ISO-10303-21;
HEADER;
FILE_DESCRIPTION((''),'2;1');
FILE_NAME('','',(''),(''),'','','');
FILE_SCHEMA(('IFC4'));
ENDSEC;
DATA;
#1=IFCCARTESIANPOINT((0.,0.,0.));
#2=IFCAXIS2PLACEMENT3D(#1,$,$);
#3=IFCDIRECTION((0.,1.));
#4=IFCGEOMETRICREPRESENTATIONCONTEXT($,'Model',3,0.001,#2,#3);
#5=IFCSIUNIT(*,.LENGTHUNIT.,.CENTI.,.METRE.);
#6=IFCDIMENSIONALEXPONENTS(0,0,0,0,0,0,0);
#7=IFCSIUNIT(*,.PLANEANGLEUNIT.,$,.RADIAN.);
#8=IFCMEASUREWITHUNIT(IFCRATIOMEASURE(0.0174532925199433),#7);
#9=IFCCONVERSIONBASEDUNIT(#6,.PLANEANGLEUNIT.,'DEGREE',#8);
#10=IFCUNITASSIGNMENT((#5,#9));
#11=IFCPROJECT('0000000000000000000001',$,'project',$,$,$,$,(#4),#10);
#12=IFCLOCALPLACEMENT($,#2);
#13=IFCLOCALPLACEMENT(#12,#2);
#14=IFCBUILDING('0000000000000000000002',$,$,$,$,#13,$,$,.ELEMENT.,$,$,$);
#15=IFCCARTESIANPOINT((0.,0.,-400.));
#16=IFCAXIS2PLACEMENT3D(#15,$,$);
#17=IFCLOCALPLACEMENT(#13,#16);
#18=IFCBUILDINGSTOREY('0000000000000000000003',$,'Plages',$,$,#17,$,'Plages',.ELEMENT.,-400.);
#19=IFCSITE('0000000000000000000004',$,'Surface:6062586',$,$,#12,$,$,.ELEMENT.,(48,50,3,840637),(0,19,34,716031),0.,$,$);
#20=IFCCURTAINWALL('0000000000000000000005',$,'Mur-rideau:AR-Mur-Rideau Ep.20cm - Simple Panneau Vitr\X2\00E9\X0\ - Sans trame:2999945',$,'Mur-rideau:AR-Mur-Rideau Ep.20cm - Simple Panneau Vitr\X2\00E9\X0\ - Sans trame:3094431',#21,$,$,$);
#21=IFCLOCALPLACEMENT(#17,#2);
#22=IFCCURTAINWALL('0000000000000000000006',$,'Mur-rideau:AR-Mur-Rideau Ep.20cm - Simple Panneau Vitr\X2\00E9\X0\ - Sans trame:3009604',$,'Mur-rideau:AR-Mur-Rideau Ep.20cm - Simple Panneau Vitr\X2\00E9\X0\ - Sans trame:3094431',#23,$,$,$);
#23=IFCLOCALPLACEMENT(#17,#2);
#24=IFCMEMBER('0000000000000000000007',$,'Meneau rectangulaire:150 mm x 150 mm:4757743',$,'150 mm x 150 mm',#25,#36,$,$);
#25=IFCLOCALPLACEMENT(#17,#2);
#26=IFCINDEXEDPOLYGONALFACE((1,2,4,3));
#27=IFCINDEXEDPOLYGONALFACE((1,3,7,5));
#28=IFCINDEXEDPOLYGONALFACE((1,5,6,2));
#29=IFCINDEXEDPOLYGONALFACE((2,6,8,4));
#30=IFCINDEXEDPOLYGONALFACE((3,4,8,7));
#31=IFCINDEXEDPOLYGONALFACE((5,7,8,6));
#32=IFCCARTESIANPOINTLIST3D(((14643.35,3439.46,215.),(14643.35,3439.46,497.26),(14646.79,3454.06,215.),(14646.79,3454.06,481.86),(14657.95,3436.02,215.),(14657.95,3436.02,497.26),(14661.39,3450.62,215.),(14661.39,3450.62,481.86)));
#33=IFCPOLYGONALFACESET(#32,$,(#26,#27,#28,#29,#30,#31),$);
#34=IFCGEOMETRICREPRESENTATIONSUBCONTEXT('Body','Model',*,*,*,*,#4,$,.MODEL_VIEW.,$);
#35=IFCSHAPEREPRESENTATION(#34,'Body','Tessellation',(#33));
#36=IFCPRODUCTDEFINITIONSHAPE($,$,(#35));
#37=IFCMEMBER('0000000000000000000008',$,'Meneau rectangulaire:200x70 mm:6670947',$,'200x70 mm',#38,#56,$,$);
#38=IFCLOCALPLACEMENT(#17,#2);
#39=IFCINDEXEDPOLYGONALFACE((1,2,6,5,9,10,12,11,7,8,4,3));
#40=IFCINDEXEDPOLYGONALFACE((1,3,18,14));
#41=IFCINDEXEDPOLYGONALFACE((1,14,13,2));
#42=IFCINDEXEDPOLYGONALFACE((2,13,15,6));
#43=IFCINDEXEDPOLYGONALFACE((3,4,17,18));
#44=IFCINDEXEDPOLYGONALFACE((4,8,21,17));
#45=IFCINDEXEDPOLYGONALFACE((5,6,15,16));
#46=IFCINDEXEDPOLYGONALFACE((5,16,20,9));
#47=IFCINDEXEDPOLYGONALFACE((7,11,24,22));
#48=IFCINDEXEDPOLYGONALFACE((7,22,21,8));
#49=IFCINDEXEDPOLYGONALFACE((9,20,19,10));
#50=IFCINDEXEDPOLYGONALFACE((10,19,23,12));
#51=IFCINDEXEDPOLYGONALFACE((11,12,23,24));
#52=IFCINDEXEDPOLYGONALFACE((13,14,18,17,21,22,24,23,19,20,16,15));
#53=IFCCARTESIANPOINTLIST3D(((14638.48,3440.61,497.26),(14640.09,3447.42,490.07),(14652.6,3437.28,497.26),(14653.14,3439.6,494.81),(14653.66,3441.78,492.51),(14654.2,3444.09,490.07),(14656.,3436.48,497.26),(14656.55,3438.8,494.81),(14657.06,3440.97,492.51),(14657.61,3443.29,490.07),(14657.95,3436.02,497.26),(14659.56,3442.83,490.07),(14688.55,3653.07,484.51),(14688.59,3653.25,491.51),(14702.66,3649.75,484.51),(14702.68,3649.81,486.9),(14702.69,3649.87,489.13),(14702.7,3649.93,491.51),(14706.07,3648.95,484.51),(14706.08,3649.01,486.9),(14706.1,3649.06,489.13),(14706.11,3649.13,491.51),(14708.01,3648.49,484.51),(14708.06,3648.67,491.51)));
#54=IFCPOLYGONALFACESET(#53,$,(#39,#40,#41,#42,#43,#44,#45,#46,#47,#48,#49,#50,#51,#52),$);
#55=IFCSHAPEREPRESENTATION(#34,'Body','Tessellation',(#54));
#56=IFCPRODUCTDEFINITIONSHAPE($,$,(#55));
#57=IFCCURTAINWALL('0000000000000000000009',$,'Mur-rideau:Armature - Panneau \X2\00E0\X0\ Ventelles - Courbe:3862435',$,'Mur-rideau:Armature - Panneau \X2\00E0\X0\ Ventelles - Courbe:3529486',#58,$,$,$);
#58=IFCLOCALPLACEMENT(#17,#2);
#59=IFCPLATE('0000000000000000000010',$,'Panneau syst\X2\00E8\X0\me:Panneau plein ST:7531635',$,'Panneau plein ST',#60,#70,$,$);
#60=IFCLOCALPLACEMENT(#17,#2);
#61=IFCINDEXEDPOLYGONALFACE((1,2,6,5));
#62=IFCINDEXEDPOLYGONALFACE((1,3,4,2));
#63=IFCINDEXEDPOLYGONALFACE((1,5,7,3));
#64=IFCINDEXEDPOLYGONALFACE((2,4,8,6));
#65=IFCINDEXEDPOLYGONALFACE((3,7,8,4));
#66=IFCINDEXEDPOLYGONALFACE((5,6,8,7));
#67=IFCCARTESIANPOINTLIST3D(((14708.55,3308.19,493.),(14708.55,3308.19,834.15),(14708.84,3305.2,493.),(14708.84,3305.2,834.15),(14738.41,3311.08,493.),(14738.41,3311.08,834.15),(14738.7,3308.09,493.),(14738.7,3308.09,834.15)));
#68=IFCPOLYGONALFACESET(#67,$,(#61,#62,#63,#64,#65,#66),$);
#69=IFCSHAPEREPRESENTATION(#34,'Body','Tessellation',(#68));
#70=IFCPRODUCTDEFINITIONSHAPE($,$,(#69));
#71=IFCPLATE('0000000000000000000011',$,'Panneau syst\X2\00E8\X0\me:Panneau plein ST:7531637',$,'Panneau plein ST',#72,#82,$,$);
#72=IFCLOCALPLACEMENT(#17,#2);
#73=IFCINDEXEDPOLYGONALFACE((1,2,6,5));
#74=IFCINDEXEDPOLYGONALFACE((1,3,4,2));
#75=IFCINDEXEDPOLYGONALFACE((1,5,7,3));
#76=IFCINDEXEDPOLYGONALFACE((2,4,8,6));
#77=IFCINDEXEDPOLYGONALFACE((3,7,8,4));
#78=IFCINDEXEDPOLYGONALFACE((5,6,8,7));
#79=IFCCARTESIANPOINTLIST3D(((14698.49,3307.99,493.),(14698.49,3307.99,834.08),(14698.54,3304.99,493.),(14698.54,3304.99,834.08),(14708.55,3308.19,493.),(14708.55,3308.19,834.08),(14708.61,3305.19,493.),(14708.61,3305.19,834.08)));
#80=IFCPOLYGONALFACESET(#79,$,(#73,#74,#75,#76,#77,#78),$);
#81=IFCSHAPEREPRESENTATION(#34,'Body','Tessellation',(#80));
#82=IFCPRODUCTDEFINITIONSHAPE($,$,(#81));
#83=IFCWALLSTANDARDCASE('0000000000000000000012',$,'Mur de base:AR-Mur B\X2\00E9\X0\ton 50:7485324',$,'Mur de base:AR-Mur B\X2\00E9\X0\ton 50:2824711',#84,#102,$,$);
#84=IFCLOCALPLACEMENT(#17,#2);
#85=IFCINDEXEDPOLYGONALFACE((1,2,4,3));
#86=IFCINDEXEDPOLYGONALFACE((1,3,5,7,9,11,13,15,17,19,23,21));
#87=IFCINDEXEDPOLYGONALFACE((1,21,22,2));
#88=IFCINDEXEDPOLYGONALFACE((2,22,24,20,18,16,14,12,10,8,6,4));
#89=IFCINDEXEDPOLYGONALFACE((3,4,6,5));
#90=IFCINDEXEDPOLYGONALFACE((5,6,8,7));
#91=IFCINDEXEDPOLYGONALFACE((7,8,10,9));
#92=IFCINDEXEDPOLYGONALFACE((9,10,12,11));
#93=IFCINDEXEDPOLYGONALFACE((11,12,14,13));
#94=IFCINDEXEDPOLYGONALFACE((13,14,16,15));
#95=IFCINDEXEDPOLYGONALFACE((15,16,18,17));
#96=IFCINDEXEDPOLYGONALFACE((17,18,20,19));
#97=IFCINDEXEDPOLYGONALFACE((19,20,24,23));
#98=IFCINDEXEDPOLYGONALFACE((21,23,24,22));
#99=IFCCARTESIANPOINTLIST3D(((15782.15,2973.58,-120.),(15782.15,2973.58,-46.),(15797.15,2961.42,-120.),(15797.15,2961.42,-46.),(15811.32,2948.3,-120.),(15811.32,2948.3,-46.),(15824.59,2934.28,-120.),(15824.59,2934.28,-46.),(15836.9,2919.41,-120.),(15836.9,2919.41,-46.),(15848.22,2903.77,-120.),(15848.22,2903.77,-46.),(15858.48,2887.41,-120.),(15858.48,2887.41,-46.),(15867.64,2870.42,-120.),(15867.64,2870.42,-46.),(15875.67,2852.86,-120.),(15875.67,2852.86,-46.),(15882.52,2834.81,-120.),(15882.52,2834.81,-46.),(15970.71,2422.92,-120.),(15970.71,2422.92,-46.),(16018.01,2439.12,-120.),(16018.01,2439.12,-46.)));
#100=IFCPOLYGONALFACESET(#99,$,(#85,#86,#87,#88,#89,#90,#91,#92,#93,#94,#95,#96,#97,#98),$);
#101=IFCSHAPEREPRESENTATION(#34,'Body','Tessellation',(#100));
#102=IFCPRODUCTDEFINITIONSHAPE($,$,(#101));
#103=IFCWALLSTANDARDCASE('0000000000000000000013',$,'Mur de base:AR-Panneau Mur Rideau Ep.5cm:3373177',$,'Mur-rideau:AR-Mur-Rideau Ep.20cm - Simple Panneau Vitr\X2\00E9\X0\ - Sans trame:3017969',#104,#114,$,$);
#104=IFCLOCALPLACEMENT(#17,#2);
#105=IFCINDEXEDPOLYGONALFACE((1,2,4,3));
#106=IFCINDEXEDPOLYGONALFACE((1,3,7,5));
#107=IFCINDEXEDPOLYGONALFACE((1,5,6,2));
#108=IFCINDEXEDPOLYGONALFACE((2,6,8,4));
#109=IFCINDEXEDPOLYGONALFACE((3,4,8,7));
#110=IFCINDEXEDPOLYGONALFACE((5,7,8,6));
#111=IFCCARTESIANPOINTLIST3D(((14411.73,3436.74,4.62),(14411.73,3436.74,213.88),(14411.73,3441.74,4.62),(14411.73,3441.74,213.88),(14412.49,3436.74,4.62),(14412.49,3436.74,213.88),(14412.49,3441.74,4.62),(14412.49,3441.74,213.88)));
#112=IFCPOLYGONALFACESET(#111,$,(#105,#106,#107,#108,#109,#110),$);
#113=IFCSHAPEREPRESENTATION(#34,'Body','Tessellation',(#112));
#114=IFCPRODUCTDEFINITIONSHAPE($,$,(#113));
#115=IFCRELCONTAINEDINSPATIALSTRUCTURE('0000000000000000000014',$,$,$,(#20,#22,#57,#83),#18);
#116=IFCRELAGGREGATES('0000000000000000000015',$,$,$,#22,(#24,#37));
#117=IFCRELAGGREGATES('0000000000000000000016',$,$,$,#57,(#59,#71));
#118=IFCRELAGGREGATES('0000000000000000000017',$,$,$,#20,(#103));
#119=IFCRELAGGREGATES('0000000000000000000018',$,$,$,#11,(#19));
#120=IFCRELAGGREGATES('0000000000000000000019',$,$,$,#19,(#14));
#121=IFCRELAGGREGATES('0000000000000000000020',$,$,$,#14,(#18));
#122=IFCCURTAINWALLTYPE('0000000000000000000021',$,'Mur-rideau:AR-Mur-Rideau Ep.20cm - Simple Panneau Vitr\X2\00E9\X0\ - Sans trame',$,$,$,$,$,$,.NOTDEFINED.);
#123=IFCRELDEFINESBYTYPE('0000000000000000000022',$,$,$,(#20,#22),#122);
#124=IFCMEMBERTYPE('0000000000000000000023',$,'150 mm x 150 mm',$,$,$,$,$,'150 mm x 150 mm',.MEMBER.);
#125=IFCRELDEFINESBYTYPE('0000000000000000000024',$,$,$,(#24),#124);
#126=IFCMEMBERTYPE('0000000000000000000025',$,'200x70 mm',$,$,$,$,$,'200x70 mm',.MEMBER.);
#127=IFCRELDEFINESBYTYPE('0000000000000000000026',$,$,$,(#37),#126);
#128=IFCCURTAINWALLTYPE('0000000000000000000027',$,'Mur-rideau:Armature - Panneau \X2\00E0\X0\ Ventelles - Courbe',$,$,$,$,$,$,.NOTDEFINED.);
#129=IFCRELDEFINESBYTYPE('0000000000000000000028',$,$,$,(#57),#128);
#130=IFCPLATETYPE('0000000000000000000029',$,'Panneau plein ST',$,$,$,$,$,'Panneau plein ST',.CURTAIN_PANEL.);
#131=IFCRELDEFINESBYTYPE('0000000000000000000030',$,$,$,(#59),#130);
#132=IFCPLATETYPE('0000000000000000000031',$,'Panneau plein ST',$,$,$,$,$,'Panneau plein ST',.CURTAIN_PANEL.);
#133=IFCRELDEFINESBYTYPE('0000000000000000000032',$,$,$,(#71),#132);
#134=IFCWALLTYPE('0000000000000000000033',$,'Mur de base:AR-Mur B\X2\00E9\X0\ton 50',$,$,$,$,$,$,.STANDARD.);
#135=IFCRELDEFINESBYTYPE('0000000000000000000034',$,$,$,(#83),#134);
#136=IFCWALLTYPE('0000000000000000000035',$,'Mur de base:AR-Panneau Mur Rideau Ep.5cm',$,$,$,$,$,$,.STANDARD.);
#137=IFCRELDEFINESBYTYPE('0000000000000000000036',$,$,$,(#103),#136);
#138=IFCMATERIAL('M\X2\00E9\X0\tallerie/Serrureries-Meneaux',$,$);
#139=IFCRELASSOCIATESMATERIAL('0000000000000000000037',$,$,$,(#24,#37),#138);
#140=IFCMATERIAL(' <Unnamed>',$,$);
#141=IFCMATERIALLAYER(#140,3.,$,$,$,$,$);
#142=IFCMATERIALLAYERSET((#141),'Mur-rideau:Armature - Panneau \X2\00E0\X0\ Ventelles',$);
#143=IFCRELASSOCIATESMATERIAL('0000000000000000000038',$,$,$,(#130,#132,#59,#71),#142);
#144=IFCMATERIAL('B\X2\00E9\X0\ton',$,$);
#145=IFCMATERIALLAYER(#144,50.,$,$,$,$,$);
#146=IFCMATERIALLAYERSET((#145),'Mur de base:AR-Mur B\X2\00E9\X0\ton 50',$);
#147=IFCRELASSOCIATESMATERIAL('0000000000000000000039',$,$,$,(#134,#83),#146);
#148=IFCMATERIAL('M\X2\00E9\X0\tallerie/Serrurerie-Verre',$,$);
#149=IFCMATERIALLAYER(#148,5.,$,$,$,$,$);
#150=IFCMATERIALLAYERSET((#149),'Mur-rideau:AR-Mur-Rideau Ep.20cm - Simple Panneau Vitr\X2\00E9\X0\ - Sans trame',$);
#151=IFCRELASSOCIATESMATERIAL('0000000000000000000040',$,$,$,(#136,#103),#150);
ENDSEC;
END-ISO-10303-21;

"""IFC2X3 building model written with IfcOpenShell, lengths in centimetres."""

from ifc_helpers import new_model, entity, si_unit, converted_unit, direction, frame, frame_2d, origin, origin_2d_with_axis, place, context, subcontext, project, spatial, polyline, circle_curve, parameter, trimmed, segment, composite_curve, rectangle, outline, extrude, clip, halfspace, source, transform, mapped, material, layer, layer_set, layer_usage, type_object, type_shapes, element, aggregate, save


model = new_model("IFC2X3")

# Units and contexts
model_context = context("Model", 3, precision=0.001, world=origin(), true_north=direction((0.0, 1.0)))
body_context = subcontext(model_context, "Body", "Model", "MODEL_VIEW")
ifc_project = project(units=[si_unit("LENGTHUNIT", "METRE", prefix="CENTI"), converted_unit("PLANEANGLEUNIT", "DEGREE", entity("IfcRatioMeasure", 0.0174532925199433), si_unit("PLANEANGLEUNIT", "RADIAN"), dimensions=[0, 0, 0, 0, 0, 0, 0])], contexts=[model_context])

# Site, building, storey
site_placement = place(None, origin())
site = spatial("IfcSite", under=ifc_project, at=site_placement, Name="Surface:6062586", CompositionType="ELEMENT", RefLatitude=(48, 50, 3, 840637), RefLongitude=(0, 19, 34, 716031), RefElevation=0.0)
building_placement = place(site_placement, origin())
building = spatial("IfcBuilding", under=site, at=building_placement, CompositionType="ELEMENT")
storey_placement = place(building_placement, frame((0.0, 0.0, -400.0)))
storey = spatial("IfcBuildingStorey", under=building, at=storey_placement, Name="Plages", LongName="Plages", CompositionType="ELEMENT", Elevation=-400.0)

# Curtain walls, members
curtain_wall_type_1 = type_object("IfcCurtainWallType", Name="Mur-rideau:AR-Mur-Rideau Ep.20cm - Simple Panneau Vitré - Sans trame", PredefinedType="NOTDEFINED")
curtain_wall_1_placement = place(storey_placement, frame((0.0, 0.0, 400.0)))
curtain_wall_1 = element("IfcCurtainWall", 1, at=curtain_wall_1_placement, inside=storey, type_object=curtain_wall_type_1, Name="Mur-rideau:AR-Mur-Rideau Ep.20cm - Simple Panneau Vitré - Sans trame:2999945", ObjectType="Mur-rideau:AR-Mur-Rideau Ep.20cm - Simple Panneau Vitré - Sans trame:3094431")
ifc_material_1 = material(Name="Métallerie/Serrureries-Meneaux")
curtain_wall_2_placement = place(storey_placement, frame((0.0, 0.0, 400.0)))
curtain_wall_2 = element("IfcCurtainWall", 2, at=curtain_wall_2_placement, inside=storey, type_object=curtain_wall_type_1, Name="Mur-rideau:AR-Mur-Rideau Ep.20cm - Simple Panneau Vitré - Sans trame:3009604", ObjectType="Mur-rideau:AR-Mur-Rideau Ep.20cm - Simple Panneau Vitré - Sans trame:3094431")
member_type_1 = type_object("IfcMemberType", Name="150 mm x 150 mm", ElementType="150 mm x 150 mm", PredefinedType="MEMBER")
shared_shape_1 = source(origin(), body_context, "Body", "Clipping", [
    clip(extrude(rectangle(XDim=15.0, YDim=15.0, at=origin_2d_with_axis()), frame((-7.5, 3.75, -282.26), z_axis=(0.0, 0.0, 1.0), x_axis=(0.0, -1.0, 0.0)), (0.0, 0.0, 1.0), 282.26), halfspace(frame((0.0, -30.48, -282.26), z_axis=(-0.716339, 0.0, -0.697753), x_axis=(0.697753, 0.0, -0.716339)), False)),
])
type_shapes(member_type_1, [shared_shape_1])
member_1_placement = place(storey_placement, frame((14654.3, 3436.88, 215.0), z_axis=(0.0, 0.0, -1.0), x_axis=(-0.229349, -0.973344, 0.0)))
member_1 = element("IfcMember", 3, at=member_1_placement, type_object=member_type_1, material=ifc_material_1, Name="Meneau rectangulaire:150 mm x 150 mm:4757743", ObjectType="150 mm x 150 mm", context=body_context, shape_type="MappedRepresentation", body=[
    mapped(shared_shape_1, transform((0.0, 0.0, 0.0), scale=1.0)),
])
member_type_2 = type_object("IfcMemberType", Name="200x70 mm", ElementType="200x70 mm", PredefinedType="MEMBER")
shared_shape_2 = source(origin(), body_context, "Body", "Clipping", [
    clip(extrude(outline(polyline([(-14.17, -3.5), (0.33, -3.5), (0.33, -1.12), (3.83, -1.12), (3.83, -3.5), (5.83, -3.5), (5.83, 3.5), (3.83, 3.5), (3.83, 1.12), (0.33, 1.12), (0.33, 3.5), (-14.17, 3.5), (-14.17, -3.5)])), frame((-3.5, 2.08, -218.55), z_axis=(0.0, 0.0, 1.0), x_axis=(0.0, -1.0, 0.0)), (0.0, 0.0, 1.0), 218.55), halfspace(frame((0.0, -30.48, 0.0), z_axis=(-0.716339, 0.0, 0.697753), x_axis=(0.697753, 0.0, 0.716339)), False)),
])
type_shapes(member_type_2, [shared_shape_2])
member_2_placement = place(storey_placement, frame((14654.3, 3436.88, 497.26), z_axis=(-0.229269, -0.973008, 0.026282), x_axis=(0.006028, 0.025581, 0.999655)))
member_2 = element("IfcMember", 4, at=member_2_placement, type_object=member_type_2, material=ifc_material_1, Name="Meneau rectangulaire:200x70 mm:6670947", ObjectType="200x70 mm", context=body_context, shape_type="MappedRepresentation", body=[
    mapped(shared_shape_2, transform((0.0, 0.0, 0.0), scale=1.0)),
])
aggregate(curtain_wall_2, [member_1, member_2])

# Shared definitions
ifc_material_2 = material(Name=" <Unnamed>")

# Curtain wall, plates
curtain_wall_type_2 = type_object("IfcCurtainWallType", Name="Mur-rideau:Armature - Panneau à Ventelles - Courbe", PredefinedType="NOTDEFINED")
curtain_wall_3_placement = place(storey_placement, frame((0.0, 0.0, 400.0)))
curtain_wall_3 = element("IfcCurtainWall", 5, at=curtain_wall_3_placement, inside=storey, type_object=curtain_wall_type_2, Name="Mur-rideau:Armature - Panneau à Ventelles - Courbe:3862435", ObjectType="Mur-rideau:Armature - Panneau à Ventelles - Courbe:3529486")
ifc_layer_1 = layer(ifc_material_2, 3.0)
ifc_layer_set_1 = layer_set([ifc_layer_1], Name="Mur-rideau:Armature - Panneau à Ventelles")
ifc_layer_usage_1 = layer_usage(ifc_layer_set_1, "AXIS3", "POSITIVE", 0.05)
plate_type_1 = type_object("IfcPlateType", Name="Panneau plein ST", ElementType="Panneau plein ST", PredefinedType="CURTAIN_PANEL", material=ifc_layer_set_1)
shared_shape_3 = source(origin(), body_context, "Body", "SweptSolid", [
    extrude(rectangle(XDim=3.0, YDim=30.0, at=frame_2d((0.0, 0.0), x_axis=(1.0, 0.0))), frame((0.0, 1.5, 0.0), z_axis=(0.0, 0.0, 1.0), x_axis=(0.0, 1.0, 0.0)), (0.0, 0.0, 1.0), 341.15),
])
type_shapes(plate_type_1, [shared_shape_3])
plate_1_placement = place(curtain_wall_3_placement, frame((14723.48, 3309.63, 93.0), z_axis=(0.0, 0.0, 1.0), x_axis=(-0.995352, -0.096301, 0.0)))
plate_1 = element("IfcPlate", 6, at=plate_1_placement, type_object=plate_type_1, material=ifc_layer_usage_1, Name="Panneau système:Panneau plein ST:7531635", ObjectType="Panneau plein ST", context=body_context, shape_type="MappedRepresentation", body=[
    mapped(shared_shape_3, transform((0.0, 0.0, 0.0), scale=1.0)),
])
ifc_layer_usage_2 = layer_usage(ifc_layer_set_1, "AXIS3", "POSITIVE", 0.05)
plate_type_2 = type_object("IfcPlateType", Name="Panneau plein ST", ElementType="Panneau plein ST", PredefinedType="CURTAIN_PANEL", material=ifc_layer_set_1)
shared_shape_4 = source(origin(), body_context, "Body", "SweptSolid", [
    extrude(rectangle(XDim=3.0, YDim=10.07, at=origin_2d_with_axis()), frame((0.0, 1.5, 0.0), z_axis=(0.0, 0.0, 1.0), x_axis=(0.0, 1.0, 0.0)), (0.0, 0.0, 1.0), 341.08),
])
type_shapes(plate_type_2, [shared_shape_4])
plate_2_placement = place(curtain_wall_3_placement, frame((14703.52, 3308.09, 93.0), z_axis=(0.0, 0.0, 1.0), x_axis=(-0.999813, -0.019362, 0.0)))
plate_2 = element("IfcPlate", 7, at=plate_2_placement, type_object=plate_type_2, material=ifc_layer_usage_2, Name="Panneau système:Panneau plein ST:7531637", ObjectType="Panneau plein ST", context=body_context, shape_type="MappedRepresentation", body=[
    mapped(shared_shape_4, transform((0.0, 0.0, 0.0), scale=1.0)),
])
aggregate(curtain_wall_3, [plate_1, plate_2])

# Wall
ifc_material_3 = material(Name="Béton")
ifc_layer_2 = layer(ifc_material_3, 50.0)
ifc_layer_set_2 = layer_set([ifc_layer_2], Name="Mur de base:AR-Mur Béton 50")
ifc_layer_usage_3 = layer_usage(ifc_layer_set_2, "AXIS2", "NEGATIVE", 25.0)
wall_type_1 = type_object("IfcWallType", Name="Mur de base:AR-Mur Béton 50", PredefinedType="STANDARD", material=ifc_layer_set_2)
wall_1_placement = place(storey_placement, frame((15994.36, 2431.02, -120.0), z_axis=(0.0, 0.0, 1.0), x_axis=(-0.323948, 0.946075, 0.0)))
element("IfcWallStandardCase", 8, at=wall_1_placement, inside=storey, type_object=wall_type_1, material=ifc_layer_usage_3, Name="Mur de base:AR-Mur Béton 50:7485324", ObjectType="Mur de base:AR-Mur Béton 50:2824711", context=body_context, shape_type="SweptSolid", body=[
    extrude(outline(composite_curve([segment(trimmed(circle_curve(frame_2d((418.25, 268.3), x_axis=(-0.323948, -0.946075)), 293.3), [parameter(18.901829)], [parameter(52.85185)], True, "PARAMETER"), True, "CONTINUOUS"), segment(polyline([(582.05, 25.0), (0.0, 25.0)]), True, "CONTINUOUS"), segment(polyline([(0.0, 25.0), (0.0, -25.0)]), True, "CONTINUOUS"), segment(polyline([(0.0, -25.0), (418.25, -25.0)]), True, "CONTINUOUS")], self_intersect=False)), origin(), (0.0, 0.0, 1.0), 74.0),
])

# Wall, opening
ifc_material_4 = material(Name="Métallerie/Serrurerie-Verre")
ifc_layer_3 = layer(ifc_material_4, 5.0)
ifc_layer_set_3 = layer_set([ifc_layer_3], Name="Mur-rideau:AR-Mur-Rideau Ep.20cm - Simple Panneau Vitré - Sans trame")
ifc_layer_usage_4 = layer_usage(ifc_layer_set_3, "AXIS2", "NEGATIVE", 2.5)
wall_type_2 = type_object("IfcWallType", Name="Mur de base:AR-Panneau Mur Rideau Ep.5cm", PredefinedType="STANDARD", material=ifc_layer_set_3)
wall_2_placement = place(storey_placement, frame((14412.49, 3439.24, 4.62), z_axis=(0.0, 0.0, 1.0), x_axis=(-1.0, 0.0, 0.0)))
wall_2 = element("IfcWallStandardCase", 9, at=wall_2_placement, type_object=wall_type_2, material=ifc_layer_usage_4, Name="Mur de base:AR-Panneau Mur Rideau Ep.5cm:3373177", ObjectType="Mur-rideau:AR-Mur-Rideau Ep.20cm - Simple Panneau Vitré - Sans trame:3017969", context=body_context, shape_type="SweptSolid", body=[
    extrude(rectangle(XDim=0.76, YDim=5.0, at=frame_2d((0.0, 0.0), x_axis=(1.0, 0.0))), frame((0.38, 0.0, 0.0)), (0.0, 0.0, 1.0), 209.26),
])
opening_placement = place(wall_2_placement, frame((0.76, -2.5, -4.62)))
element("IfcOpeningElement", 10, at=opening_placement, cuts=wall_2, ObjectType="Opening", context=body_context, shape_type="SweptSolid", body=[
    extrude(rectangle(XDim=215.0, YDim=210.0, at=frame_2d((107.5, 105.0), x_axis=(1.0, 0.0))), frame((0.0, 0.0, 0.0), z_axis=(0.0, 1.0, 0.0), x_axis=(0.0, 0.0, 1.0)), (0.0, 0.0, 1.0), 5.0),
])
aggregate(curtain_wall_1, [wall_2])

save(model, "model.ifc")
